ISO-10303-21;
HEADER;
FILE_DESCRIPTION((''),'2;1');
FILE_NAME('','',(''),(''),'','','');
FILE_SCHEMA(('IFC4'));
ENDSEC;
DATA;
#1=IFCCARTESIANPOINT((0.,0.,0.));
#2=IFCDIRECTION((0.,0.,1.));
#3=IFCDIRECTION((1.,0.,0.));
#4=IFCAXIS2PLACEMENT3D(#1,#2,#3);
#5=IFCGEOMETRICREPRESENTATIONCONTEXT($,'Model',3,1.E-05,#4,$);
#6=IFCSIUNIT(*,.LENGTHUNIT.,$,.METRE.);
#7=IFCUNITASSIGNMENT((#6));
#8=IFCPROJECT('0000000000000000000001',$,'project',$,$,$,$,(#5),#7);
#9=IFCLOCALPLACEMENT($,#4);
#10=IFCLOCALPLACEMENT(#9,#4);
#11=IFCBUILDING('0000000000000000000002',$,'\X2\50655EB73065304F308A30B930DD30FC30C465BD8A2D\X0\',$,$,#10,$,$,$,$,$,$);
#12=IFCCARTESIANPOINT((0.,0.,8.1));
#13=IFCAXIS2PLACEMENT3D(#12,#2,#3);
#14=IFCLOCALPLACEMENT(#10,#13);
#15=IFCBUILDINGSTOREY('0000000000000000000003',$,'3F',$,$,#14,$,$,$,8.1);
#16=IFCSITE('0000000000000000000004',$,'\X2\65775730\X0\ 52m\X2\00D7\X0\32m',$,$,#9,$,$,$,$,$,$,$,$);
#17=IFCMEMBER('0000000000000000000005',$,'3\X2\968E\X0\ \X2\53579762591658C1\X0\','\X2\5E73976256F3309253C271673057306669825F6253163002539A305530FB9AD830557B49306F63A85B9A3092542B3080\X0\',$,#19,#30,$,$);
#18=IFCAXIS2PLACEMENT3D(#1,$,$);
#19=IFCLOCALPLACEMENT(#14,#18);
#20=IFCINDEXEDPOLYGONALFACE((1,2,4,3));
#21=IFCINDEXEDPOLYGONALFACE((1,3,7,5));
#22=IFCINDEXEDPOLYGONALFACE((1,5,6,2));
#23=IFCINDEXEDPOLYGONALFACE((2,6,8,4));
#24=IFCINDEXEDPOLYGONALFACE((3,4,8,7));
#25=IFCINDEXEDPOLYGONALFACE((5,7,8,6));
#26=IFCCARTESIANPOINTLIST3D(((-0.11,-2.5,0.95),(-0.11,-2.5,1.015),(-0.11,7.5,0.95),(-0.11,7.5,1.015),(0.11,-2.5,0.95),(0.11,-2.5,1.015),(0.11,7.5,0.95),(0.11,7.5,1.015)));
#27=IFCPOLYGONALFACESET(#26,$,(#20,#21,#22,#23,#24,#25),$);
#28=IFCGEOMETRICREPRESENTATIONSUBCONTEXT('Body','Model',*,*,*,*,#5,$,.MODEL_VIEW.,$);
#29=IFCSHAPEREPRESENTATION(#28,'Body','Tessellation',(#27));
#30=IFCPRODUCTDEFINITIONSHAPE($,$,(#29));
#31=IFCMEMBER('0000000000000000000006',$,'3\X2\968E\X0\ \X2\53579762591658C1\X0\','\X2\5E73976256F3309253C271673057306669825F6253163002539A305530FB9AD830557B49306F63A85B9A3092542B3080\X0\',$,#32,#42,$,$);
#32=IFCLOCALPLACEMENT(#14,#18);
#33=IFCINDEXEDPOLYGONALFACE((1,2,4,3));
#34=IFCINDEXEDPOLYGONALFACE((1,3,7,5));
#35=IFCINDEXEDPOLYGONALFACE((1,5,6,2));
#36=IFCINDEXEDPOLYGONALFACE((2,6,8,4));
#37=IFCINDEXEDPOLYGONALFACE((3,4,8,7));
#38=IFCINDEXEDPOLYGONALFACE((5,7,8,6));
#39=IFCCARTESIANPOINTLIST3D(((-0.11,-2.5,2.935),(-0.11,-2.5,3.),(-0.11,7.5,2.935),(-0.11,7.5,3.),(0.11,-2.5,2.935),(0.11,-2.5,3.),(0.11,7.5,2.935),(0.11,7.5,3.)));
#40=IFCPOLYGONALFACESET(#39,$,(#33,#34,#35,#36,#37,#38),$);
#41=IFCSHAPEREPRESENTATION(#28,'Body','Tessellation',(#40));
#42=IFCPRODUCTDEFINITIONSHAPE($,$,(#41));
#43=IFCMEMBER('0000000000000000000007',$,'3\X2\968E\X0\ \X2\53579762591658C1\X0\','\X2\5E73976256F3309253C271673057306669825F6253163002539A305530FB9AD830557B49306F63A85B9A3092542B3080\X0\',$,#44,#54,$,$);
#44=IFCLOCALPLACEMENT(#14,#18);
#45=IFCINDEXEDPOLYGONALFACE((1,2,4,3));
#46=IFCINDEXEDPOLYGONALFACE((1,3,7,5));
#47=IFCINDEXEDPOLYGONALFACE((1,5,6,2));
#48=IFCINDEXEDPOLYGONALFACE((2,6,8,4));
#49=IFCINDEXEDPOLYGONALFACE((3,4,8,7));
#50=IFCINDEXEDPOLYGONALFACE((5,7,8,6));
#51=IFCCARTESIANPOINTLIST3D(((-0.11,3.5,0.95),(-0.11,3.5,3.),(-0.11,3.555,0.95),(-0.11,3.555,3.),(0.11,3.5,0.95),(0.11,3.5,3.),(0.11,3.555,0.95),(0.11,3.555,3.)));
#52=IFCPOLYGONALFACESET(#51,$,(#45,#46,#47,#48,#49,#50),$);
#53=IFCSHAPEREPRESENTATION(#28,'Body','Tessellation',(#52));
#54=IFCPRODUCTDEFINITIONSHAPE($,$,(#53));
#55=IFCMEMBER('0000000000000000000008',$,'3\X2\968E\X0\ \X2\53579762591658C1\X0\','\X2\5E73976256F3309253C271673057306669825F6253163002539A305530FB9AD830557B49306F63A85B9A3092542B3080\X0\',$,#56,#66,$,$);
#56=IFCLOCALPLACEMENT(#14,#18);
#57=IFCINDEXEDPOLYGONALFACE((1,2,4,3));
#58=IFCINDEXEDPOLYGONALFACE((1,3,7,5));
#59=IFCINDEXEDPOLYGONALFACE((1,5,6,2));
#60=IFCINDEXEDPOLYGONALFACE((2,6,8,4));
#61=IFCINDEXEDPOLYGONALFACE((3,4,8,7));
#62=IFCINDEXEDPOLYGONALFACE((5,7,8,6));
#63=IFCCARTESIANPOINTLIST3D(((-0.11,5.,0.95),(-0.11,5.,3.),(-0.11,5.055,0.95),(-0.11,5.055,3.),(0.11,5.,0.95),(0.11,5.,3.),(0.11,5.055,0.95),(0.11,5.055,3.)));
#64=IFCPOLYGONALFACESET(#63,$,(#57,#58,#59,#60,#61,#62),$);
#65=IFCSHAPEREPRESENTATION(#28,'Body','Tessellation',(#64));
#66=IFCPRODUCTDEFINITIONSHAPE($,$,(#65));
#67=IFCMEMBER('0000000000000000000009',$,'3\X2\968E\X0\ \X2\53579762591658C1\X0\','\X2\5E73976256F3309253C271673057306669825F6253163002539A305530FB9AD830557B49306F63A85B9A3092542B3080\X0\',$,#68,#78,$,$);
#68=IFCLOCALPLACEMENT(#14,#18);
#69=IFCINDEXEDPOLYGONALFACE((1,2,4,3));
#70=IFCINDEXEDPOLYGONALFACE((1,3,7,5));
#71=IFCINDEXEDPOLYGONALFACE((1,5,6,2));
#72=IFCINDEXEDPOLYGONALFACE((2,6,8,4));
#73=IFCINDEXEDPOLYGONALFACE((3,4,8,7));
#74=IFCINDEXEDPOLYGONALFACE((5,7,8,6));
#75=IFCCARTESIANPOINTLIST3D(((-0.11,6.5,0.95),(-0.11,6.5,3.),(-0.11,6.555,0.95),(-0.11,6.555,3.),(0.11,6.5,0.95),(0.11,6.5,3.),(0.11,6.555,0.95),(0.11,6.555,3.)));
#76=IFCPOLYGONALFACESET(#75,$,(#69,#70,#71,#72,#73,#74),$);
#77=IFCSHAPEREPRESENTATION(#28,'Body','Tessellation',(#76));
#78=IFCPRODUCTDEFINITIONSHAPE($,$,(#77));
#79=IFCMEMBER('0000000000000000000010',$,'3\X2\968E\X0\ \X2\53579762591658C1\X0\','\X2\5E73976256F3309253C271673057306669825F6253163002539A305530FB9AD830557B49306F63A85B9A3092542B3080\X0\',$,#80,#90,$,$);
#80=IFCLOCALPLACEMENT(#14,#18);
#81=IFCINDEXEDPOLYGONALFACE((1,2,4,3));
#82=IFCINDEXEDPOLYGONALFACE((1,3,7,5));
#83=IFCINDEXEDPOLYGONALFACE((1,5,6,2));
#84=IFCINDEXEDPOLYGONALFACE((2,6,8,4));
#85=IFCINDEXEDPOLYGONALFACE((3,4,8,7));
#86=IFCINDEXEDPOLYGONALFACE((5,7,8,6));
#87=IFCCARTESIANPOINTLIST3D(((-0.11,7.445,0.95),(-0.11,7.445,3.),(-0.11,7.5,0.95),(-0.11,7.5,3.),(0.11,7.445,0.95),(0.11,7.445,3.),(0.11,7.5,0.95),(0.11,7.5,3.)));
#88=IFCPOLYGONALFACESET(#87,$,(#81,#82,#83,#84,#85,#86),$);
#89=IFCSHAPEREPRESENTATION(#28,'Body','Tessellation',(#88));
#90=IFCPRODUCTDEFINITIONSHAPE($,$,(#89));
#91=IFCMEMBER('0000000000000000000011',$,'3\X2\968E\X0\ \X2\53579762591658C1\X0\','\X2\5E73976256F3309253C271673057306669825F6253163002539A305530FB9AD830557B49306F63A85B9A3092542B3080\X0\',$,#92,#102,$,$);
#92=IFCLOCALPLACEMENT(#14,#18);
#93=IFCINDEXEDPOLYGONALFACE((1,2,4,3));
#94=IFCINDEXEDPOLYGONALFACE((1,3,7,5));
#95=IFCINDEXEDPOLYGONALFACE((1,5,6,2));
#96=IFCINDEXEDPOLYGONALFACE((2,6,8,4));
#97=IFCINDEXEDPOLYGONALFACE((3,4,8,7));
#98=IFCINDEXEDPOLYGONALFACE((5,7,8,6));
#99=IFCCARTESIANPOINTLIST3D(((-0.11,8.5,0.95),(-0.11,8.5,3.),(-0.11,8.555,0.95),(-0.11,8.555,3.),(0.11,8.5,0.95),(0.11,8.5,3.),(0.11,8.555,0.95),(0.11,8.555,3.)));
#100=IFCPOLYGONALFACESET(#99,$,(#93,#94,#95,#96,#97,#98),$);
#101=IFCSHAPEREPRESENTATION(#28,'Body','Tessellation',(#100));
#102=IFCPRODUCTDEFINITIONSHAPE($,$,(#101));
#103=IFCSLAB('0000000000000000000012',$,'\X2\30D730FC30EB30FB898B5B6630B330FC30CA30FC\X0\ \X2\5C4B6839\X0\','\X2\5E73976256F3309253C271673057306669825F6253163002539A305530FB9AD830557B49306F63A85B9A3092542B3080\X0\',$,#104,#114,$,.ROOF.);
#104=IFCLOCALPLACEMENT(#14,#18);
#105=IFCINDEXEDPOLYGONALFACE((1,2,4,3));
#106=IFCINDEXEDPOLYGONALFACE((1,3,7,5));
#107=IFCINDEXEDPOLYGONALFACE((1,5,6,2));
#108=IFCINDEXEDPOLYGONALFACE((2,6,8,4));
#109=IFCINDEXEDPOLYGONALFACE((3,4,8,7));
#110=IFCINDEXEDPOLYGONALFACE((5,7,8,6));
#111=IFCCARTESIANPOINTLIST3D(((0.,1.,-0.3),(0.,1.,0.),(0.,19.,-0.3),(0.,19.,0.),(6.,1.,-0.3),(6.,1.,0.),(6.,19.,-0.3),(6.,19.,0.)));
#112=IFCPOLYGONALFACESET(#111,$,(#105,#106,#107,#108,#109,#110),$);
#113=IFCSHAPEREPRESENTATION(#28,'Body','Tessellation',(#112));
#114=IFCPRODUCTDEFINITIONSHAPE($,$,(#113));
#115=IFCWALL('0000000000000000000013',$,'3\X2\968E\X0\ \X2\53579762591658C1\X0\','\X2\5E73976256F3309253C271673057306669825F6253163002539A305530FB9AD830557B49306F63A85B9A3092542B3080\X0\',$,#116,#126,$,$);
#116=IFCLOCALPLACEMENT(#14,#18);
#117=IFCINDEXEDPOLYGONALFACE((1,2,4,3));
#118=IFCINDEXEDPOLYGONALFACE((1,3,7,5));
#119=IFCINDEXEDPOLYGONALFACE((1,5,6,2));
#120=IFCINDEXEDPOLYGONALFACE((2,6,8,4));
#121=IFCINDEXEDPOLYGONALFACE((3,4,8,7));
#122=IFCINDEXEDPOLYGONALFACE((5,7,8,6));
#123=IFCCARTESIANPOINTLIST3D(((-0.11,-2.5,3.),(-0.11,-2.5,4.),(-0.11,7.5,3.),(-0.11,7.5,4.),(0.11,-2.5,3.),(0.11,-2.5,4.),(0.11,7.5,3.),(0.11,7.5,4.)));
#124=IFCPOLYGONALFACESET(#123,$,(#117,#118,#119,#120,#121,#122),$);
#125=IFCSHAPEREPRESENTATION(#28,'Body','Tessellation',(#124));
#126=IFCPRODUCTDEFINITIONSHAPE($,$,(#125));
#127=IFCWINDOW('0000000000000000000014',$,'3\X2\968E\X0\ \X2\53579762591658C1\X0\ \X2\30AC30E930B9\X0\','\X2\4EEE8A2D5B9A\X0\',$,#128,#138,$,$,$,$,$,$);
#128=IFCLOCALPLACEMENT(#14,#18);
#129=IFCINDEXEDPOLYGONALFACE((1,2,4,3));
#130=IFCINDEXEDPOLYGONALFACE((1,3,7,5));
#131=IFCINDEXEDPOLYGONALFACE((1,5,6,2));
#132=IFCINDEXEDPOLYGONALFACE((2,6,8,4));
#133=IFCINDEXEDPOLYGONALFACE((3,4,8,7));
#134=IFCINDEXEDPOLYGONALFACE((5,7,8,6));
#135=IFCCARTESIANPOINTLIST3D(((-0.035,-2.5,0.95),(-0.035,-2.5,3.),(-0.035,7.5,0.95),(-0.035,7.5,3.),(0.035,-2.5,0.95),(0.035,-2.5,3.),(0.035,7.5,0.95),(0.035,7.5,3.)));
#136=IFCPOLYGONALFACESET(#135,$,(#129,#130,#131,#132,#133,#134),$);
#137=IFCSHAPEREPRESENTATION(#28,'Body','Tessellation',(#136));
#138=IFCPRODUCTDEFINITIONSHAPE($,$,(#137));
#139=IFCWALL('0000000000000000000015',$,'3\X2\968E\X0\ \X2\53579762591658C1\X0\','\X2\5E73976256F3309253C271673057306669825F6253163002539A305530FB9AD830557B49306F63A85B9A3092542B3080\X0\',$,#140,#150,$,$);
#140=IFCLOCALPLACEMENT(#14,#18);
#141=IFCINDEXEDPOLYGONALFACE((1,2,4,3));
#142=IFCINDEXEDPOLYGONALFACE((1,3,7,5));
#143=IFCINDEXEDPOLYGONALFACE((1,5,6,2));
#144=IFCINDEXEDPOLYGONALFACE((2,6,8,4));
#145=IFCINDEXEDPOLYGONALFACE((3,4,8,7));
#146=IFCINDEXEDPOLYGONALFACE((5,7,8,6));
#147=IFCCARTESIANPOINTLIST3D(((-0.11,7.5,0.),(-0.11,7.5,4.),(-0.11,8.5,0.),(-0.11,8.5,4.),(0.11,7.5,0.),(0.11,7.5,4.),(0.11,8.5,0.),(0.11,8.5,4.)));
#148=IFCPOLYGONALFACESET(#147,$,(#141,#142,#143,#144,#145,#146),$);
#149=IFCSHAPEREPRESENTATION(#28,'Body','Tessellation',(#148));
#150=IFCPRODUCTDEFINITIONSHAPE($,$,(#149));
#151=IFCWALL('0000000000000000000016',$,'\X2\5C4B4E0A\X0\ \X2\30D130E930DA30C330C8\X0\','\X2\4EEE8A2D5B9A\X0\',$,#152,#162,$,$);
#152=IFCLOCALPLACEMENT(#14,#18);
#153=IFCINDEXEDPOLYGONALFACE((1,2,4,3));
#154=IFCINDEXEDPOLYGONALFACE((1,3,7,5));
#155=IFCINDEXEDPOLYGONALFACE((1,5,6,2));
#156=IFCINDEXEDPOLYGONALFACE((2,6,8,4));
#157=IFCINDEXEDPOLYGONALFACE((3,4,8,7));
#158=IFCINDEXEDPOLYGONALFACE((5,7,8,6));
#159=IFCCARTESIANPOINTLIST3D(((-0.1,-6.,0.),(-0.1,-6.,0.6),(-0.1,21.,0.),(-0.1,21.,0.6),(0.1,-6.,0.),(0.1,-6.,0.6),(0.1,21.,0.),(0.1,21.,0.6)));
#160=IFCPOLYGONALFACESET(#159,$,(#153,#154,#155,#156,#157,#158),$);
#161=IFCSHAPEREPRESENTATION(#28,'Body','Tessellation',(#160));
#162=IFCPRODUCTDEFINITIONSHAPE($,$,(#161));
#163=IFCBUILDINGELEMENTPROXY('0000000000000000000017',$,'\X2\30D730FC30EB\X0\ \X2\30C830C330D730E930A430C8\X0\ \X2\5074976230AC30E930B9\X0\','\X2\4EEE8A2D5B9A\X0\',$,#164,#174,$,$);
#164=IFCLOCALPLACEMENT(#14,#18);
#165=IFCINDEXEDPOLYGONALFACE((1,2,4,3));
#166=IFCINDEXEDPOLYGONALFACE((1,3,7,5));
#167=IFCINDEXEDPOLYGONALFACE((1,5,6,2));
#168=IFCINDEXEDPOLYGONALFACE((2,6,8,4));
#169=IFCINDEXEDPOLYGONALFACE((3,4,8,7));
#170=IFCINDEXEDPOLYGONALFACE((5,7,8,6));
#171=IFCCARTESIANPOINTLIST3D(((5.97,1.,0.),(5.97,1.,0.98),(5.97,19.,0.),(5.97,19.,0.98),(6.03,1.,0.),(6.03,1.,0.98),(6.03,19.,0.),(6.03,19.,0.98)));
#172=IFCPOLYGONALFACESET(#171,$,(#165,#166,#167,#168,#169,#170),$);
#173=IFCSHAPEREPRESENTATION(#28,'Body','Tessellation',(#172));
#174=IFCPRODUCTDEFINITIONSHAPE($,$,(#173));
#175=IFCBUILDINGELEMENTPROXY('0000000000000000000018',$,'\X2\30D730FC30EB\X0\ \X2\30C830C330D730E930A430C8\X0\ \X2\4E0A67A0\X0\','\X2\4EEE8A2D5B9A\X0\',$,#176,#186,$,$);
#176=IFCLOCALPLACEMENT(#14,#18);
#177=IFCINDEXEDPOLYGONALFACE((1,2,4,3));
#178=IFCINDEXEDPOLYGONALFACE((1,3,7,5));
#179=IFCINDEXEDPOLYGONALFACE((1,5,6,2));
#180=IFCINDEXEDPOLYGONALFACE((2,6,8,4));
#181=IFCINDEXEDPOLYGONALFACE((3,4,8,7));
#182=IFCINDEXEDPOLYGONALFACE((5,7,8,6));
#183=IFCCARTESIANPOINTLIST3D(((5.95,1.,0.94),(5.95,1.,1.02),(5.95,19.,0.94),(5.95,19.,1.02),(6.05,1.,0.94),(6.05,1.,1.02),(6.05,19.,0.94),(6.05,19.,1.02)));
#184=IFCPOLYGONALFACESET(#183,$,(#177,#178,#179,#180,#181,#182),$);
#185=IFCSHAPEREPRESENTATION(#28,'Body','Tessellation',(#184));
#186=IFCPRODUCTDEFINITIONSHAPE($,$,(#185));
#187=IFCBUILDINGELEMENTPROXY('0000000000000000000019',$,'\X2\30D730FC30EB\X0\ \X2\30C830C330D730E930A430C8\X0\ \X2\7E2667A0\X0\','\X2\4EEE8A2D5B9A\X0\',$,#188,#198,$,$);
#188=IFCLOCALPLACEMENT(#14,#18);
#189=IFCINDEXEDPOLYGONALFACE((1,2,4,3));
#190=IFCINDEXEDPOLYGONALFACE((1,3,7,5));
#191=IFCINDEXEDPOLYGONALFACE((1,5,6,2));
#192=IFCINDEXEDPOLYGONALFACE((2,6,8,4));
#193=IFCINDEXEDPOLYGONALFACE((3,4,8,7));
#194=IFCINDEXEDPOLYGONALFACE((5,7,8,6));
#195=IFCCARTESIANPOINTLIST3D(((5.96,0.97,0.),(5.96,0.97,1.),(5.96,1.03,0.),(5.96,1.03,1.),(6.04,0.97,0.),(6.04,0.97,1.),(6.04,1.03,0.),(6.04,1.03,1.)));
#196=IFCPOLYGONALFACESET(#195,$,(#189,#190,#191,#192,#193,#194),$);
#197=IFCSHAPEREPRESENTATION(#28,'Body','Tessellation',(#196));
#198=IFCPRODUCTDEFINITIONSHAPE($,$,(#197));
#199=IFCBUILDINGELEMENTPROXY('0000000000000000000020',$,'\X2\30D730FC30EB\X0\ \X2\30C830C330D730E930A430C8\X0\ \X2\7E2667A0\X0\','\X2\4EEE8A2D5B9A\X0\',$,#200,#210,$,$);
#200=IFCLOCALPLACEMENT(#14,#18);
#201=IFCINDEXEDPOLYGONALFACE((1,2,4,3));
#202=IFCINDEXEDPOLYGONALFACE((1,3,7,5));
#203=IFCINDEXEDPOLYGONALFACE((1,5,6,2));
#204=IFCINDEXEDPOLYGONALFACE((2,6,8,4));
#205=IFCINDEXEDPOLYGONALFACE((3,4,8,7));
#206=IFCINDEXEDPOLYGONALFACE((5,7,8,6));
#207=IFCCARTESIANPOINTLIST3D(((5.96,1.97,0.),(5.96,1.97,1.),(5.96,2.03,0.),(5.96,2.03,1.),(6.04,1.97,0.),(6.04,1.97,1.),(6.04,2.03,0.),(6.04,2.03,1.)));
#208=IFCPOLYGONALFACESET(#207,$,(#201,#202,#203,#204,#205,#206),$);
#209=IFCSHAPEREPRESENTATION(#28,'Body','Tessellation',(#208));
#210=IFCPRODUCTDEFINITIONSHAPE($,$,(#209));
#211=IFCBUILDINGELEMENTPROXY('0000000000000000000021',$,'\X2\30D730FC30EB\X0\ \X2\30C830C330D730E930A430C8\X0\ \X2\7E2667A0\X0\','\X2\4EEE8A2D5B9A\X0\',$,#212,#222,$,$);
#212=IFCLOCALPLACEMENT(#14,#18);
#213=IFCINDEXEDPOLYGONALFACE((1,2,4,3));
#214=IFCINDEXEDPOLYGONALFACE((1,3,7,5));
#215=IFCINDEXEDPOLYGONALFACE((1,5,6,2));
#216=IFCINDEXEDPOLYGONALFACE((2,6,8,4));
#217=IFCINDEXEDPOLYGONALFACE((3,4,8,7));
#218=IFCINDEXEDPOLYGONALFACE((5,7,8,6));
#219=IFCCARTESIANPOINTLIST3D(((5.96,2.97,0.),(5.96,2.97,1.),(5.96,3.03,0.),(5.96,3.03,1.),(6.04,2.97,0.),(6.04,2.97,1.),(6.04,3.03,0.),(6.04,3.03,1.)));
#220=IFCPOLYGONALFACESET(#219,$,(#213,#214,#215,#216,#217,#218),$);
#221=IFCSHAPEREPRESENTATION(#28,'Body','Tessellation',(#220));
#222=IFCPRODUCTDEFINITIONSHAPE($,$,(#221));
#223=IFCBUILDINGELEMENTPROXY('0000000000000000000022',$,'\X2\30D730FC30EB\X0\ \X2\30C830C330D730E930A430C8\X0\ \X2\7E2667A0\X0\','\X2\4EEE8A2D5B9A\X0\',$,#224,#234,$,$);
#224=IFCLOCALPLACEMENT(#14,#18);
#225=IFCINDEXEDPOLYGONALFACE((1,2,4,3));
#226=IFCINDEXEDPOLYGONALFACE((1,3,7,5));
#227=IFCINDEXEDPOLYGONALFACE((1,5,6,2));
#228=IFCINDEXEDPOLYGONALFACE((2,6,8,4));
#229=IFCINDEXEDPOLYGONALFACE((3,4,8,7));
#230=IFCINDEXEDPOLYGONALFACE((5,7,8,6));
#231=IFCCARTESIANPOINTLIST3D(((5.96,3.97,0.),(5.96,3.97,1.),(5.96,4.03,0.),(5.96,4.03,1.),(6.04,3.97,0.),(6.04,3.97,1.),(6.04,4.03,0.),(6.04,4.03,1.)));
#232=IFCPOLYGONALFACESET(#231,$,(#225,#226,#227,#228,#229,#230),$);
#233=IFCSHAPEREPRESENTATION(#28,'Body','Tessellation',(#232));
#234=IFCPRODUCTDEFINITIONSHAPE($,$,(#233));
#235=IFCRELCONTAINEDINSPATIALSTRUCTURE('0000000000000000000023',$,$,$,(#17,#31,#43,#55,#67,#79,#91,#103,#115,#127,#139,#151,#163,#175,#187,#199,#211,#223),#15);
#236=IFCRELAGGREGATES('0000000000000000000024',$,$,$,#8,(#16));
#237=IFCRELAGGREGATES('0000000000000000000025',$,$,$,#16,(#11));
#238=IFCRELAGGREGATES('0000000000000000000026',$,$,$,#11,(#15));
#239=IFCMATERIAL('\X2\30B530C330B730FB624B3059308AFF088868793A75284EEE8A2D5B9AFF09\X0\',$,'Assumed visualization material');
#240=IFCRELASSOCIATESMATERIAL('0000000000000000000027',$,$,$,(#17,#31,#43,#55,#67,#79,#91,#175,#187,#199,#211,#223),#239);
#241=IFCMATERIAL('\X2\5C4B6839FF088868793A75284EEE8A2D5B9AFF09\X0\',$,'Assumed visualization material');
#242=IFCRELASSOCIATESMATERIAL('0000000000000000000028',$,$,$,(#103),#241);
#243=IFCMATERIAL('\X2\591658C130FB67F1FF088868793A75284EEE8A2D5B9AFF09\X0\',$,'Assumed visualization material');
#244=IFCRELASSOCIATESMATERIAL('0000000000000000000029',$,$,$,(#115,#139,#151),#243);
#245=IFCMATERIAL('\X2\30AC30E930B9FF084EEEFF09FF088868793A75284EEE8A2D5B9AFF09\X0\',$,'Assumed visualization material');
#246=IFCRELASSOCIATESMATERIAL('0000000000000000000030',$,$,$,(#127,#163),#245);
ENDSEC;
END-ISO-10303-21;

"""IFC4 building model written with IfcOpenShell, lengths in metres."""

from ifc_helpers import new_model, si_unit, frame, origin_with_axes, place, context, subcontext, project, spatial, rectangle, extrude, material, element, save


model = new_model("IFC4")

# Units and contexts
model_context = context("Model", 3, precision=1e-05, world=origin_with_axes())
body_context = subcontext(model_context, "Body", "Model", "MODEL_VIEW")
ifc_project = project(units=[si_unit("LENGTHUNIT", "METRE")], contexts=[model_context])

# Site, building, storey
site_placement = place(None, origin_with_axes())
site = spatial("IfcSite", under=ifc_project, at=site_placement, Name="敷地 52m×32m")
building_placement = place(site_placement, origin_with_axes())
building = spatial("IfcBuilding", under=site, at=building_placement, Name="健康づくりスポーツ施設")
storey_placement = place(building_placement, frame((0.0, 0.0, 8.1), z_axis=(0.0, 0.0, 1.0), x_axis=(1.0, 0.0, 0.0)))
storey = spatial("IfcBuildingStorey", under=building, at=storey_placement, Name="3F", Elevation=8.1)

# Members
ifc_material_1 = material(Name="サッシ・手すり（表示用仮設定）", Category="Assumed visualization material")
for number, where, z_axis, x_axis, name in (
    (1, (0.0, 2.5, 0.95), (0.0, 0.0, 1.0), (1.0, 0.0, 0.0), "3階 南面外壁"),
    (2, (0.0, 2.5, 2.935), (0.0, 0.0, 1.0), (1.0, 0.0, 0.0), "3階 南面外壁"),
):
    element("IfcMember", number, at=place(storey_placement, frame(where, z_axis=z_axis, x_axis=x_axis)), inside=storey, material=ifc_material_1, Name=name, Description="平面図を参照して概形化。厚さ・高さ等は推定を含む", context=body_context, shape_type="SweptSolid", body=[
        extrude(rectangle(XDim=0.22, YDim=10.0), origin_with_axes(), (0.0, 0.0, 1.0), 0.065),
    ])
for number, where, z_axis, x_axis, name in (
    (3, (0.0, 3.5275, 0.95), (0.0, 0.0, 1.0), (1.0, 0.0, 0.0), "3階 南面外壁"),
    (4, (0.0, 5.0275, 0.95), (0.0, 0.0, 1.0), (1.0, 0.0, 0.0), "3階 南面外壁"),
    (5, (0.0, 6.5275, 0.95), (0.0, 0.0, 1.0), (1.0, 0.0, 0.0), "3階 南面外壁"),
    (6, (0.0, 7.4725, 0.95), (0.0, 0.0, 1.0), (1.0, 0.0, 0.0), "3階 南面外壁"),
    (7, (0.0, 8.5275, 0.95), (0.0, 0.0, 1.0), (1.0, 0.0, 0.0), "3階 南面外壁"),
):
    element("IfcMember", number, at=place(storey_placement, frame(where, z_axis=z_axis, x_axis=x_axis)), inside=storey, material=ifc_material_1, Name=name, Description="平面図を参照して概形化。厚さ・高さ等は推定を含む", context=body_context, shape_type="SweptSolid", body=[
        extrude(rectangle(XDim=0.22, YDim=0.055), origin_with_axes(), (0.0, 0.0, 1.0), 2.05),
    ])

# Slab
ifc_material_2 = material(Name="屋根（表示用仮設定）", Category="Assumed visualization material")
slab_placement = place(storey_placement, frame((3.0, 10.0, -0.3), z_axis=(0.0, 0.0, 1.0), x_axis=(1.0, 0.0, 0.0)))
element("IfcSlab", 8, at=slab_placement, inside=storey, material=ifc_material_2, Name="プール・見学コーナー 屋根", Description="平面図を参照して概形化。厚さ・高さ等は推定を含む", PredefinedType="ROOF", context=body_context, shape_type="SweptSolid", body=[
    extrude(rectangle(XDim=6.0, YDim=18.0), origin_with_axes(), (0.0, 0.0, 1.0), 0.3),
])

# Wall
ifc_material_3 = material(Name="外壁・柱（表示用仮設定）", Category="Assumed visualization material")
wall_1_placement = place(storey_placement, frame((0.0, 2.5, 3.0), z_axis=(0.0, 0.0, 1.0), x_axis=(1.0, 0.0, 0.0)))
element("IfcWall", 9, at=wall_1_placement, inside=storey, material=ifc_material_3, Name="3階 南面外壁", Description="平面図を参照して概形化。厚さ・高さ等は推定を含む", context=body_context, shape_type="SweptSolid", body=[
    extrude(rectangle(XDim=0.22, YDim=10.0), origin_with_axes(), (0.0, 0.0, 1.0), 1.0),
])

# Window
ifc_material_4 = material(Name="ガラス（仮）（表示用仮設定）", Category="Assumed visualization material")
window_placement = place(storey_placement, frame((0.0, 2.5, 0.95), z_axis=(0.0, 0.0, 1.0), x_axis=(1.0, 0.0, 0.0)))
element("IfcWindow", 10, at=window_placement, inside=storey, material=ifc_material_4, Name="3階 南面外壁 ガラス", Description="仮設定", context=body_context, shape_type="SweptSolid", body=[
    extrude(rectangle(XDim=0.07, YDim=10.0), origin_with_axes(), (0.0, 0.0, 1.0), 2.05),
])

# Walls
wall_2_placement = place(storey_placement, frame((0.0, 8.0, 0.0), z_axis=(0.0, 0.0, 1.0), x_axis=(1.0, 0.0, 0.0)))
element("IfcWall", 11, at=wall_2_placement, inside=storey, material=ifc_material_3, Name="3階 南面外壁", Description="平面図を参照して概形化。厚さ・高さ等は推定を含む", context=body_context, shape_type="SweptSolid", body=[
    extrude(rectangle(XDim=0.22, YDim=1.0), origin_with_axes(), (0.0, 0.0, 1.0), 4.0),
])
wall_3_placement = place(storey_placement, frame((0.0, 7.5, 0.0), z_axis=(0.0, 0.0, 1.0), x_axis=(1.0, 0.0, 0.0)))
element("IfcWall", 12, at=wall_3_placement, inside=storey, material=ifc_material_3, Name="屋上 パラペット", Description="仮設定", context=body_context, shape_type="SweptSolid", body=[
    extrude(rectangle(XDim=0.2, YDim=27.0), origin_with_axes(), (0.0, 0.0, 1.0), 0.6),
])

# Building element proxies
proxy_1_placement = place(storey_placement, frame((6.0, 10.0, 0.0), z_axis=(0.0, 0.0, 1.0), x_axis=(1.0, 0.0, 0.0)))
element("IfcBuildingElementProxy", 13, at=proxy_1_placement, inside=storey, material=ifc_material_4, Name="プール トップライト 側面ガラス", Description="仮設定", context=body_context, shape_type="SweptSolid", body=[
    extrude(rectangle(XDim=0.06, YDim=18.0), origin_with_axes(), (0.0, 0.0, 1.0), 0.98),
])
proxy_2_placement = place(storey_placement, frame((6.0, 10.0, 0.94), z_axis=(0.0, 0.0, 1.0), x_axis=(1.0, 0.0, 0.0)))
element("IfcBuildingElementProxy", 14, at=proxy_2_placement, inside=storey, material=ifc_material_1, Name="プール トップライト 上枠", Description="仮設定", context=body_context, shape_type="SweptSolid", body=[
    extrude(rectangle(XDim=0.1, YDim=18.0), origin_with_axes(), (0.0, 0.0, 1.0), 0.08),
])
for number, where, z_axis, x_axis, name in (
    (15, (6.0, 1.0, 0.0), (0.0, 0.0, 1.0), (1.0, 0.0, 0.0), "プール トップライト 縦枠"),
    (16, (6.0, 2.0, 0.0), (0.0, 0.0, 1.0), (1.0, 0.0, 0.0), "プール トップライト 縦枠"),
    (17, (6.0, 3.0, 0.0), (0.0, 0.0, 1.0), (1.0, 0.0, 0.0), "プール トップライト 縦枠"),
    (18, (6.0, 4.0, 0.0), (0.0, 0.0, 1.0), (1.0, 0.0, 0.0), "プール トップライト 縦枠"),
):
    element("IfcBuildingElementProxy", number, at=place(storey_placement, frame(where, z_axis=z_axis, x_axis=x_axis)), inside=storey, material=ifc_material_1, Name=name, Description="仮設定", context=body_context, shape_type="SweptSolid", body=[
        extrude(rectangle(XDim=0.08, YDim=0.06), origin_with_axes(), (0.0, 0.0, 1.0), 1.0),
    ])

save(model, "model.ifc")
